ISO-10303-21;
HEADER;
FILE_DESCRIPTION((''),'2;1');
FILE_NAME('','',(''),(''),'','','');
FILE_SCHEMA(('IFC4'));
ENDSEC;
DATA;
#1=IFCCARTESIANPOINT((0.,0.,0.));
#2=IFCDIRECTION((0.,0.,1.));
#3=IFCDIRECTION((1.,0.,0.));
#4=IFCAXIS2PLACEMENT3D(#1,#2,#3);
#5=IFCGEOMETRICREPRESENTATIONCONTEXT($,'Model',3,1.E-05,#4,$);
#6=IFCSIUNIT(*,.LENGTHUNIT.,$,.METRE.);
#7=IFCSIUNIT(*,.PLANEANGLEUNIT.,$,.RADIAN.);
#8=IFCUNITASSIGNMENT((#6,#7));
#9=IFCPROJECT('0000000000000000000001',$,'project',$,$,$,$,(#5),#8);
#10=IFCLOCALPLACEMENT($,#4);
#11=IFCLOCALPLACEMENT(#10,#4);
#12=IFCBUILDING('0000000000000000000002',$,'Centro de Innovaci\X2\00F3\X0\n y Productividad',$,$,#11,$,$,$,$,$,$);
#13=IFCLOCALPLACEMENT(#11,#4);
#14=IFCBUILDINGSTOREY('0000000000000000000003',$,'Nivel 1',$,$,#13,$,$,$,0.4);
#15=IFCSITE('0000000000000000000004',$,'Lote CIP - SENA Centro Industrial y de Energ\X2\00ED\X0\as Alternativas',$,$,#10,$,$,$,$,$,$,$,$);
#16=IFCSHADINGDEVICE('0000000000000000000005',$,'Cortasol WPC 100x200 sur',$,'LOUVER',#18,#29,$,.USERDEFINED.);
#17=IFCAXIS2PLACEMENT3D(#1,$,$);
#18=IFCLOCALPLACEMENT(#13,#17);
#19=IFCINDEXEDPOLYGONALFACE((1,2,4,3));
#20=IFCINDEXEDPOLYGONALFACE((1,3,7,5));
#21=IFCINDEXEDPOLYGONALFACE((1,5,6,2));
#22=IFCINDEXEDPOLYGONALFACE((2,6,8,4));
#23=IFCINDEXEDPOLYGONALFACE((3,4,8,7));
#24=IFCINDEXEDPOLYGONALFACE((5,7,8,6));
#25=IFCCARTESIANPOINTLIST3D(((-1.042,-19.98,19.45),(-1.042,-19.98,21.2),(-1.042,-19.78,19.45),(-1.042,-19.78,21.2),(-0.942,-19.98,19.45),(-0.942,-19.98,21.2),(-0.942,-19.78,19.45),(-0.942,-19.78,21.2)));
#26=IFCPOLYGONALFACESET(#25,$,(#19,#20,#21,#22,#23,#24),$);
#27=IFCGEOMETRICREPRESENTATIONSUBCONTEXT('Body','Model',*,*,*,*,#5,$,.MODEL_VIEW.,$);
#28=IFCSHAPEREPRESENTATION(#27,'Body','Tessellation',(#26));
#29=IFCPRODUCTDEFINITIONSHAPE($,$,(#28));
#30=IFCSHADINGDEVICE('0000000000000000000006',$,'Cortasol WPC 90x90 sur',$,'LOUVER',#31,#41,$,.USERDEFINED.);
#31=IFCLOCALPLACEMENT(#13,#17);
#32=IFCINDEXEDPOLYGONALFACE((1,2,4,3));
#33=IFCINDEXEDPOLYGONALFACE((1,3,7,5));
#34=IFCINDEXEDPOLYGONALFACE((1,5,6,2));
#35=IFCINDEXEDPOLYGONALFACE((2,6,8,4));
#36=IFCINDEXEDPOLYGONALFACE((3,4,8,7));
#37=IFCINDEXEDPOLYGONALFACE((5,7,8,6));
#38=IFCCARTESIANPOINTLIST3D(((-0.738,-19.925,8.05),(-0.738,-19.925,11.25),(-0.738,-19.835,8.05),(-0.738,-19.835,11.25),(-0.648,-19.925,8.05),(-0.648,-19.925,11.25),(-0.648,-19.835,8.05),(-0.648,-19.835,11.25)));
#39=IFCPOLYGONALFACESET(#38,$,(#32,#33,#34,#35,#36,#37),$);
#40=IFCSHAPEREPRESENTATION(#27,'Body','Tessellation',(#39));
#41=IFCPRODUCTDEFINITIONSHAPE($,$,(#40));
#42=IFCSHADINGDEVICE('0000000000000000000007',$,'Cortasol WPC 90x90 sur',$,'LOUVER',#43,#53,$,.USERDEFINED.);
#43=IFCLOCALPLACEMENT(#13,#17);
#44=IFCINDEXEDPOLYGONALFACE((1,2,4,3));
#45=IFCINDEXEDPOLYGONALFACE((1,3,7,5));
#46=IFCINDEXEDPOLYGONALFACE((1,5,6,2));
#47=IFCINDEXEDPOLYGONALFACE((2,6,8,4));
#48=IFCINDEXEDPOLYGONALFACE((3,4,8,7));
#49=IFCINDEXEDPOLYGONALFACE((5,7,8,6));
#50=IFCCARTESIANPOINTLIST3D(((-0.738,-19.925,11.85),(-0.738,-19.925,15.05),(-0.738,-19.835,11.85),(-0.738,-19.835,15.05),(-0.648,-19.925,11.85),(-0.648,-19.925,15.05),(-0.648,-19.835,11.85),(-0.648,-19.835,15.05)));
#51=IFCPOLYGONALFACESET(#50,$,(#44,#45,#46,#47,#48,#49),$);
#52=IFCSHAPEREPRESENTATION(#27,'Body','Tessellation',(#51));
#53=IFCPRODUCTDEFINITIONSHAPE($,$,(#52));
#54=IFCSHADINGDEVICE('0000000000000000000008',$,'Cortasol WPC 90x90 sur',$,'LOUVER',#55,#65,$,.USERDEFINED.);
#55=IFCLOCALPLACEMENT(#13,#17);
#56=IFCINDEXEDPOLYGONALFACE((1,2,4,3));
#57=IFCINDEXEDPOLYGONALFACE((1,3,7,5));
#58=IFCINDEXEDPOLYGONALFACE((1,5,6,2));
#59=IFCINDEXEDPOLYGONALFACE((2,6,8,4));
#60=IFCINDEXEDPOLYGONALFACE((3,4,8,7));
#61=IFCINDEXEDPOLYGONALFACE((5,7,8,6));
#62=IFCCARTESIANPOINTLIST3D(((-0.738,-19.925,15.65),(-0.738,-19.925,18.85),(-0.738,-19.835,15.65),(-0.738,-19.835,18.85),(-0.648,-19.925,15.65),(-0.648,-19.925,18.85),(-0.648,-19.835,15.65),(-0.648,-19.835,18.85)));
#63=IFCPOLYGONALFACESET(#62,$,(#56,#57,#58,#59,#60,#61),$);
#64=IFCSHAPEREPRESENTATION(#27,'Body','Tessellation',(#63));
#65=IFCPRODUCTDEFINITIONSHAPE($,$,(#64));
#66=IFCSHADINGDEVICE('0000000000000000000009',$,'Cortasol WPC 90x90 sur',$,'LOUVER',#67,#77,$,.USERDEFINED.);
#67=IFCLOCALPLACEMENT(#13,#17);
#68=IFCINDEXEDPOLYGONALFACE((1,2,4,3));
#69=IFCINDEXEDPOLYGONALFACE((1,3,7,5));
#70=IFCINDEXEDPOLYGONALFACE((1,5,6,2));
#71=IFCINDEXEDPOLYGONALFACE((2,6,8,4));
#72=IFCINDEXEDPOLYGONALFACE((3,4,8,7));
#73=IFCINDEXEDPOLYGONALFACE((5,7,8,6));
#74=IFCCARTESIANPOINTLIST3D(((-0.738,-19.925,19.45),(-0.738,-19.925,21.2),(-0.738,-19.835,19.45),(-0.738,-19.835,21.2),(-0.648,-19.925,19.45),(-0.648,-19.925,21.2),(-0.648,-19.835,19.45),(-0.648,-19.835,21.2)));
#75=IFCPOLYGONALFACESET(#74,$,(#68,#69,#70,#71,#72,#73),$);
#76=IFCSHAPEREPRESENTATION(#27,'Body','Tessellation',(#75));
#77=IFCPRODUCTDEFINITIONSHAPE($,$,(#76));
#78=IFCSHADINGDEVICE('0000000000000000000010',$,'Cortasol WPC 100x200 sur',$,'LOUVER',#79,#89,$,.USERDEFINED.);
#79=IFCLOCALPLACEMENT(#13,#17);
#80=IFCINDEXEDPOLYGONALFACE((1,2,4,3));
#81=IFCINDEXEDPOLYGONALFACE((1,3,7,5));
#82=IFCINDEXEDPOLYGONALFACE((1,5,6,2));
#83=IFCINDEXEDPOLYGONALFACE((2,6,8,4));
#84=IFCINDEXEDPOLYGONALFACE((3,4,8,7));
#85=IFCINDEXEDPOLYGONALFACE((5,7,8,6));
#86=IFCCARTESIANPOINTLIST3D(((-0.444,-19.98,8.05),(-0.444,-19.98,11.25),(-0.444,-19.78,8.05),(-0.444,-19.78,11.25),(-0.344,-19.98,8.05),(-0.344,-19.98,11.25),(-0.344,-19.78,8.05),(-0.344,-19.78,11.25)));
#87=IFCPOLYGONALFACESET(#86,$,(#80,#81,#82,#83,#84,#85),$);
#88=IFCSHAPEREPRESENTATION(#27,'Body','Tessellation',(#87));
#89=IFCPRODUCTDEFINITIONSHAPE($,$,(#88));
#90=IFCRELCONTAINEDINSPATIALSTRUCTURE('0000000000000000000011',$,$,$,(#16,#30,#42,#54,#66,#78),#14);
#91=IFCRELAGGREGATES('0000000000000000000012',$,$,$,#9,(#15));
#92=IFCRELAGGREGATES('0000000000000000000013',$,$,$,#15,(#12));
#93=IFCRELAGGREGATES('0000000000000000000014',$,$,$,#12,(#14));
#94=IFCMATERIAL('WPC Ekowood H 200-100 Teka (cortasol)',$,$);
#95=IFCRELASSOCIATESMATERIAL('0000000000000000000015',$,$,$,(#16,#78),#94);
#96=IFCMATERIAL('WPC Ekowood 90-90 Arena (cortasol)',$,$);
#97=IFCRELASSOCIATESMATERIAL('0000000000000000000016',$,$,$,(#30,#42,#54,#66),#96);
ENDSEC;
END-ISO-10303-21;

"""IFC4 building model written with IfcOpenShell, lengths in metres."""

from ifc_helpers import new_model, si_unit, frame, origin_with_axes, place, context, subcontext, project, spatial, polyline, outline, extrude, material, element, save


model = new_model("IFC4")

# Units and contexts
model_context = context("Model", 3, precision=1e-05, world=origin_with_axes())
body_context = subcontext(model_context, "Body", "Model", "MODEL_VIEW")
ifc_project = project(units=[si_unit("LENGTHUNIT", "METRE"), si_unit("PLANEANGLEUNIT", "RADIAN")], contexts=[model_context])

# Site, building, storey
site_placement = place(None, origin_with_axes())
site = spatial("IfcSite", under=ifc_project, at=site_placement, Name="Lote CIP - SENA Centro Industrial y de Energías Alternativas")
building_placement = place(site_placement, origin_with_axes())
building = spatial("IfcBuilding", under=site, at=building_placement, Name="Centro de Innovación y Productividad")
storey_placement = place(building_placement, origin_with_axes())
storey = spatial("IfcBuildingStorey", under=building, at=storey_placement, Name="Nivel 1", Elevation=0.4)

# Shading devices
ifc_material_1 = material(Name="WPC Ekowood H 200-100 Teka (cortasol)")
ifc_material_2 = material(Name="WPC Ekowood 90-90 Arena (cortasol)")
shading_device_1_placement = place(storey_placement, origin_with_axes())
element("IfcShadingDevice", 1, at=shading_device_1_placement, inside=storey, material=ifc_material_1, Name="Cortasol WPC 100x200 sur", ObjectType="LOUVER", PredefinedType="USERDEFINED", context=body_context, shape_type="SweptSolid", body=[
    extrude(outline(polyline([(-1.042, -19.98), (-1.042, -19.78), (-0.942, -19.78), (-0.942, -19.98), (-1.042, -19.98)])), frame((0.0, 0.0, 19.45)), (0.0, 0.0, 1.0), 1.75),
])
shading_device_2_placement = place(storey_placement, origin_with_axes())
element("IfcShadingDevice", 2, at=shading_device_2_placement, inside=storey, material=ifc_material_2, Name="Cortasol WPC 90x90 sur", ObjectType="LOUVER", PredefinedType="USERDEFINED", context=body_context, shape_type="SweptSolid", body=[
    extrude(outline(polyline([(-0.738, -19.925), (-0.738, -19.835), (-0.648, -19.835), (-0.648, -19.925), (-0.738, -19.925)])), frame((0.0, 0.0, 8.05)), (0.0, 0.0, 1.0), 3.2),
])
shading_device_3_placement = place(storey_placement, origin_with_axes())
element("IfcShadingDevice", 3, at=shading_device_3_placement, inside=storey, material=ifc_material_2, Name="Cortasol WPC 90x90 sur", ObjectType="LOUVER", PredefinedType="USERDEFINED", context=body_context, shape_type="SweptSolid", body=[
    extrude(outline(polyline([(-0.738, -19.925), (-0.738, -19.835), (-0.648, -19.835), (-0.648, -19.925), (-0.738, -19.925)])), frame((0.0, 0.0, 11.85)), (0.0, 0.0, 1.0), 3.2),
])
shading_device_4_placement = place(storey_placement, origin_with_axes())
element("IfcShadingDevice", 4, at=shading_device_4_placement, inside=storey, material=ifc_material_2, Name="Cortasol WPC 90x90 sur", ObjectType="LOUVER", PredefinedType="USERDEFINED", context=body_context, shape_type="SweptSolid", body=[
    extrude(outline(polyline([(-0.738, -19.925), (-0.738, -19.835), (-0.648, -19.835), (-0.648, -19.925), (-0.738, -19.925)])), frame((0.0, 0.0, 15.65)), (0.0, 0.0, 1.0), 3.2),
])
shading_device_5_placement = place(storey_placement, origin_with_axes())
element("IfcShadingDevice", 5, at=shading_device_5_placement, inside=storey, material=ifc_material_2, Name="Cortasol WPC 90x90 sur", ObjectType="LOUVER", PredefinedType="USERDEFINED", context=body_context, shape_type="SweptSolid", body=[
    extrude(outline(polyline([(-0.738, -19.925), (-0.738, -19.835), (-0.648, -19.835), (-0.648, -19.925), (-0.738, -19.925)])), frame((0.0, 0.0, 19.45)), (0.0, 0.0, 1.0), 1.75),
])
shading_device_6_placement = place(storey_placement, origin_with_axes())
element("IfcShadingDevice", 6, at=shading_device_6_placement, inside=storey, material=ifc_material_1, Name="Cortasol WPC 100x200 sur", ObjectType="LOUVER", PredefinedType="USERDEFINED", context=body_context, shape_type="SweptSolid", body=[
    extrude(outline(polyline([(-0.444, -19.98), (-0.444, -19.78), (-0.344, -19.78), (-0.344, -19.98), (-0.444, -19.98)])), frame((0.0, 0.0, 8.05)), (0.0, 0.0, 1.0), 3.2),
])

save(model, "model.ifc")
